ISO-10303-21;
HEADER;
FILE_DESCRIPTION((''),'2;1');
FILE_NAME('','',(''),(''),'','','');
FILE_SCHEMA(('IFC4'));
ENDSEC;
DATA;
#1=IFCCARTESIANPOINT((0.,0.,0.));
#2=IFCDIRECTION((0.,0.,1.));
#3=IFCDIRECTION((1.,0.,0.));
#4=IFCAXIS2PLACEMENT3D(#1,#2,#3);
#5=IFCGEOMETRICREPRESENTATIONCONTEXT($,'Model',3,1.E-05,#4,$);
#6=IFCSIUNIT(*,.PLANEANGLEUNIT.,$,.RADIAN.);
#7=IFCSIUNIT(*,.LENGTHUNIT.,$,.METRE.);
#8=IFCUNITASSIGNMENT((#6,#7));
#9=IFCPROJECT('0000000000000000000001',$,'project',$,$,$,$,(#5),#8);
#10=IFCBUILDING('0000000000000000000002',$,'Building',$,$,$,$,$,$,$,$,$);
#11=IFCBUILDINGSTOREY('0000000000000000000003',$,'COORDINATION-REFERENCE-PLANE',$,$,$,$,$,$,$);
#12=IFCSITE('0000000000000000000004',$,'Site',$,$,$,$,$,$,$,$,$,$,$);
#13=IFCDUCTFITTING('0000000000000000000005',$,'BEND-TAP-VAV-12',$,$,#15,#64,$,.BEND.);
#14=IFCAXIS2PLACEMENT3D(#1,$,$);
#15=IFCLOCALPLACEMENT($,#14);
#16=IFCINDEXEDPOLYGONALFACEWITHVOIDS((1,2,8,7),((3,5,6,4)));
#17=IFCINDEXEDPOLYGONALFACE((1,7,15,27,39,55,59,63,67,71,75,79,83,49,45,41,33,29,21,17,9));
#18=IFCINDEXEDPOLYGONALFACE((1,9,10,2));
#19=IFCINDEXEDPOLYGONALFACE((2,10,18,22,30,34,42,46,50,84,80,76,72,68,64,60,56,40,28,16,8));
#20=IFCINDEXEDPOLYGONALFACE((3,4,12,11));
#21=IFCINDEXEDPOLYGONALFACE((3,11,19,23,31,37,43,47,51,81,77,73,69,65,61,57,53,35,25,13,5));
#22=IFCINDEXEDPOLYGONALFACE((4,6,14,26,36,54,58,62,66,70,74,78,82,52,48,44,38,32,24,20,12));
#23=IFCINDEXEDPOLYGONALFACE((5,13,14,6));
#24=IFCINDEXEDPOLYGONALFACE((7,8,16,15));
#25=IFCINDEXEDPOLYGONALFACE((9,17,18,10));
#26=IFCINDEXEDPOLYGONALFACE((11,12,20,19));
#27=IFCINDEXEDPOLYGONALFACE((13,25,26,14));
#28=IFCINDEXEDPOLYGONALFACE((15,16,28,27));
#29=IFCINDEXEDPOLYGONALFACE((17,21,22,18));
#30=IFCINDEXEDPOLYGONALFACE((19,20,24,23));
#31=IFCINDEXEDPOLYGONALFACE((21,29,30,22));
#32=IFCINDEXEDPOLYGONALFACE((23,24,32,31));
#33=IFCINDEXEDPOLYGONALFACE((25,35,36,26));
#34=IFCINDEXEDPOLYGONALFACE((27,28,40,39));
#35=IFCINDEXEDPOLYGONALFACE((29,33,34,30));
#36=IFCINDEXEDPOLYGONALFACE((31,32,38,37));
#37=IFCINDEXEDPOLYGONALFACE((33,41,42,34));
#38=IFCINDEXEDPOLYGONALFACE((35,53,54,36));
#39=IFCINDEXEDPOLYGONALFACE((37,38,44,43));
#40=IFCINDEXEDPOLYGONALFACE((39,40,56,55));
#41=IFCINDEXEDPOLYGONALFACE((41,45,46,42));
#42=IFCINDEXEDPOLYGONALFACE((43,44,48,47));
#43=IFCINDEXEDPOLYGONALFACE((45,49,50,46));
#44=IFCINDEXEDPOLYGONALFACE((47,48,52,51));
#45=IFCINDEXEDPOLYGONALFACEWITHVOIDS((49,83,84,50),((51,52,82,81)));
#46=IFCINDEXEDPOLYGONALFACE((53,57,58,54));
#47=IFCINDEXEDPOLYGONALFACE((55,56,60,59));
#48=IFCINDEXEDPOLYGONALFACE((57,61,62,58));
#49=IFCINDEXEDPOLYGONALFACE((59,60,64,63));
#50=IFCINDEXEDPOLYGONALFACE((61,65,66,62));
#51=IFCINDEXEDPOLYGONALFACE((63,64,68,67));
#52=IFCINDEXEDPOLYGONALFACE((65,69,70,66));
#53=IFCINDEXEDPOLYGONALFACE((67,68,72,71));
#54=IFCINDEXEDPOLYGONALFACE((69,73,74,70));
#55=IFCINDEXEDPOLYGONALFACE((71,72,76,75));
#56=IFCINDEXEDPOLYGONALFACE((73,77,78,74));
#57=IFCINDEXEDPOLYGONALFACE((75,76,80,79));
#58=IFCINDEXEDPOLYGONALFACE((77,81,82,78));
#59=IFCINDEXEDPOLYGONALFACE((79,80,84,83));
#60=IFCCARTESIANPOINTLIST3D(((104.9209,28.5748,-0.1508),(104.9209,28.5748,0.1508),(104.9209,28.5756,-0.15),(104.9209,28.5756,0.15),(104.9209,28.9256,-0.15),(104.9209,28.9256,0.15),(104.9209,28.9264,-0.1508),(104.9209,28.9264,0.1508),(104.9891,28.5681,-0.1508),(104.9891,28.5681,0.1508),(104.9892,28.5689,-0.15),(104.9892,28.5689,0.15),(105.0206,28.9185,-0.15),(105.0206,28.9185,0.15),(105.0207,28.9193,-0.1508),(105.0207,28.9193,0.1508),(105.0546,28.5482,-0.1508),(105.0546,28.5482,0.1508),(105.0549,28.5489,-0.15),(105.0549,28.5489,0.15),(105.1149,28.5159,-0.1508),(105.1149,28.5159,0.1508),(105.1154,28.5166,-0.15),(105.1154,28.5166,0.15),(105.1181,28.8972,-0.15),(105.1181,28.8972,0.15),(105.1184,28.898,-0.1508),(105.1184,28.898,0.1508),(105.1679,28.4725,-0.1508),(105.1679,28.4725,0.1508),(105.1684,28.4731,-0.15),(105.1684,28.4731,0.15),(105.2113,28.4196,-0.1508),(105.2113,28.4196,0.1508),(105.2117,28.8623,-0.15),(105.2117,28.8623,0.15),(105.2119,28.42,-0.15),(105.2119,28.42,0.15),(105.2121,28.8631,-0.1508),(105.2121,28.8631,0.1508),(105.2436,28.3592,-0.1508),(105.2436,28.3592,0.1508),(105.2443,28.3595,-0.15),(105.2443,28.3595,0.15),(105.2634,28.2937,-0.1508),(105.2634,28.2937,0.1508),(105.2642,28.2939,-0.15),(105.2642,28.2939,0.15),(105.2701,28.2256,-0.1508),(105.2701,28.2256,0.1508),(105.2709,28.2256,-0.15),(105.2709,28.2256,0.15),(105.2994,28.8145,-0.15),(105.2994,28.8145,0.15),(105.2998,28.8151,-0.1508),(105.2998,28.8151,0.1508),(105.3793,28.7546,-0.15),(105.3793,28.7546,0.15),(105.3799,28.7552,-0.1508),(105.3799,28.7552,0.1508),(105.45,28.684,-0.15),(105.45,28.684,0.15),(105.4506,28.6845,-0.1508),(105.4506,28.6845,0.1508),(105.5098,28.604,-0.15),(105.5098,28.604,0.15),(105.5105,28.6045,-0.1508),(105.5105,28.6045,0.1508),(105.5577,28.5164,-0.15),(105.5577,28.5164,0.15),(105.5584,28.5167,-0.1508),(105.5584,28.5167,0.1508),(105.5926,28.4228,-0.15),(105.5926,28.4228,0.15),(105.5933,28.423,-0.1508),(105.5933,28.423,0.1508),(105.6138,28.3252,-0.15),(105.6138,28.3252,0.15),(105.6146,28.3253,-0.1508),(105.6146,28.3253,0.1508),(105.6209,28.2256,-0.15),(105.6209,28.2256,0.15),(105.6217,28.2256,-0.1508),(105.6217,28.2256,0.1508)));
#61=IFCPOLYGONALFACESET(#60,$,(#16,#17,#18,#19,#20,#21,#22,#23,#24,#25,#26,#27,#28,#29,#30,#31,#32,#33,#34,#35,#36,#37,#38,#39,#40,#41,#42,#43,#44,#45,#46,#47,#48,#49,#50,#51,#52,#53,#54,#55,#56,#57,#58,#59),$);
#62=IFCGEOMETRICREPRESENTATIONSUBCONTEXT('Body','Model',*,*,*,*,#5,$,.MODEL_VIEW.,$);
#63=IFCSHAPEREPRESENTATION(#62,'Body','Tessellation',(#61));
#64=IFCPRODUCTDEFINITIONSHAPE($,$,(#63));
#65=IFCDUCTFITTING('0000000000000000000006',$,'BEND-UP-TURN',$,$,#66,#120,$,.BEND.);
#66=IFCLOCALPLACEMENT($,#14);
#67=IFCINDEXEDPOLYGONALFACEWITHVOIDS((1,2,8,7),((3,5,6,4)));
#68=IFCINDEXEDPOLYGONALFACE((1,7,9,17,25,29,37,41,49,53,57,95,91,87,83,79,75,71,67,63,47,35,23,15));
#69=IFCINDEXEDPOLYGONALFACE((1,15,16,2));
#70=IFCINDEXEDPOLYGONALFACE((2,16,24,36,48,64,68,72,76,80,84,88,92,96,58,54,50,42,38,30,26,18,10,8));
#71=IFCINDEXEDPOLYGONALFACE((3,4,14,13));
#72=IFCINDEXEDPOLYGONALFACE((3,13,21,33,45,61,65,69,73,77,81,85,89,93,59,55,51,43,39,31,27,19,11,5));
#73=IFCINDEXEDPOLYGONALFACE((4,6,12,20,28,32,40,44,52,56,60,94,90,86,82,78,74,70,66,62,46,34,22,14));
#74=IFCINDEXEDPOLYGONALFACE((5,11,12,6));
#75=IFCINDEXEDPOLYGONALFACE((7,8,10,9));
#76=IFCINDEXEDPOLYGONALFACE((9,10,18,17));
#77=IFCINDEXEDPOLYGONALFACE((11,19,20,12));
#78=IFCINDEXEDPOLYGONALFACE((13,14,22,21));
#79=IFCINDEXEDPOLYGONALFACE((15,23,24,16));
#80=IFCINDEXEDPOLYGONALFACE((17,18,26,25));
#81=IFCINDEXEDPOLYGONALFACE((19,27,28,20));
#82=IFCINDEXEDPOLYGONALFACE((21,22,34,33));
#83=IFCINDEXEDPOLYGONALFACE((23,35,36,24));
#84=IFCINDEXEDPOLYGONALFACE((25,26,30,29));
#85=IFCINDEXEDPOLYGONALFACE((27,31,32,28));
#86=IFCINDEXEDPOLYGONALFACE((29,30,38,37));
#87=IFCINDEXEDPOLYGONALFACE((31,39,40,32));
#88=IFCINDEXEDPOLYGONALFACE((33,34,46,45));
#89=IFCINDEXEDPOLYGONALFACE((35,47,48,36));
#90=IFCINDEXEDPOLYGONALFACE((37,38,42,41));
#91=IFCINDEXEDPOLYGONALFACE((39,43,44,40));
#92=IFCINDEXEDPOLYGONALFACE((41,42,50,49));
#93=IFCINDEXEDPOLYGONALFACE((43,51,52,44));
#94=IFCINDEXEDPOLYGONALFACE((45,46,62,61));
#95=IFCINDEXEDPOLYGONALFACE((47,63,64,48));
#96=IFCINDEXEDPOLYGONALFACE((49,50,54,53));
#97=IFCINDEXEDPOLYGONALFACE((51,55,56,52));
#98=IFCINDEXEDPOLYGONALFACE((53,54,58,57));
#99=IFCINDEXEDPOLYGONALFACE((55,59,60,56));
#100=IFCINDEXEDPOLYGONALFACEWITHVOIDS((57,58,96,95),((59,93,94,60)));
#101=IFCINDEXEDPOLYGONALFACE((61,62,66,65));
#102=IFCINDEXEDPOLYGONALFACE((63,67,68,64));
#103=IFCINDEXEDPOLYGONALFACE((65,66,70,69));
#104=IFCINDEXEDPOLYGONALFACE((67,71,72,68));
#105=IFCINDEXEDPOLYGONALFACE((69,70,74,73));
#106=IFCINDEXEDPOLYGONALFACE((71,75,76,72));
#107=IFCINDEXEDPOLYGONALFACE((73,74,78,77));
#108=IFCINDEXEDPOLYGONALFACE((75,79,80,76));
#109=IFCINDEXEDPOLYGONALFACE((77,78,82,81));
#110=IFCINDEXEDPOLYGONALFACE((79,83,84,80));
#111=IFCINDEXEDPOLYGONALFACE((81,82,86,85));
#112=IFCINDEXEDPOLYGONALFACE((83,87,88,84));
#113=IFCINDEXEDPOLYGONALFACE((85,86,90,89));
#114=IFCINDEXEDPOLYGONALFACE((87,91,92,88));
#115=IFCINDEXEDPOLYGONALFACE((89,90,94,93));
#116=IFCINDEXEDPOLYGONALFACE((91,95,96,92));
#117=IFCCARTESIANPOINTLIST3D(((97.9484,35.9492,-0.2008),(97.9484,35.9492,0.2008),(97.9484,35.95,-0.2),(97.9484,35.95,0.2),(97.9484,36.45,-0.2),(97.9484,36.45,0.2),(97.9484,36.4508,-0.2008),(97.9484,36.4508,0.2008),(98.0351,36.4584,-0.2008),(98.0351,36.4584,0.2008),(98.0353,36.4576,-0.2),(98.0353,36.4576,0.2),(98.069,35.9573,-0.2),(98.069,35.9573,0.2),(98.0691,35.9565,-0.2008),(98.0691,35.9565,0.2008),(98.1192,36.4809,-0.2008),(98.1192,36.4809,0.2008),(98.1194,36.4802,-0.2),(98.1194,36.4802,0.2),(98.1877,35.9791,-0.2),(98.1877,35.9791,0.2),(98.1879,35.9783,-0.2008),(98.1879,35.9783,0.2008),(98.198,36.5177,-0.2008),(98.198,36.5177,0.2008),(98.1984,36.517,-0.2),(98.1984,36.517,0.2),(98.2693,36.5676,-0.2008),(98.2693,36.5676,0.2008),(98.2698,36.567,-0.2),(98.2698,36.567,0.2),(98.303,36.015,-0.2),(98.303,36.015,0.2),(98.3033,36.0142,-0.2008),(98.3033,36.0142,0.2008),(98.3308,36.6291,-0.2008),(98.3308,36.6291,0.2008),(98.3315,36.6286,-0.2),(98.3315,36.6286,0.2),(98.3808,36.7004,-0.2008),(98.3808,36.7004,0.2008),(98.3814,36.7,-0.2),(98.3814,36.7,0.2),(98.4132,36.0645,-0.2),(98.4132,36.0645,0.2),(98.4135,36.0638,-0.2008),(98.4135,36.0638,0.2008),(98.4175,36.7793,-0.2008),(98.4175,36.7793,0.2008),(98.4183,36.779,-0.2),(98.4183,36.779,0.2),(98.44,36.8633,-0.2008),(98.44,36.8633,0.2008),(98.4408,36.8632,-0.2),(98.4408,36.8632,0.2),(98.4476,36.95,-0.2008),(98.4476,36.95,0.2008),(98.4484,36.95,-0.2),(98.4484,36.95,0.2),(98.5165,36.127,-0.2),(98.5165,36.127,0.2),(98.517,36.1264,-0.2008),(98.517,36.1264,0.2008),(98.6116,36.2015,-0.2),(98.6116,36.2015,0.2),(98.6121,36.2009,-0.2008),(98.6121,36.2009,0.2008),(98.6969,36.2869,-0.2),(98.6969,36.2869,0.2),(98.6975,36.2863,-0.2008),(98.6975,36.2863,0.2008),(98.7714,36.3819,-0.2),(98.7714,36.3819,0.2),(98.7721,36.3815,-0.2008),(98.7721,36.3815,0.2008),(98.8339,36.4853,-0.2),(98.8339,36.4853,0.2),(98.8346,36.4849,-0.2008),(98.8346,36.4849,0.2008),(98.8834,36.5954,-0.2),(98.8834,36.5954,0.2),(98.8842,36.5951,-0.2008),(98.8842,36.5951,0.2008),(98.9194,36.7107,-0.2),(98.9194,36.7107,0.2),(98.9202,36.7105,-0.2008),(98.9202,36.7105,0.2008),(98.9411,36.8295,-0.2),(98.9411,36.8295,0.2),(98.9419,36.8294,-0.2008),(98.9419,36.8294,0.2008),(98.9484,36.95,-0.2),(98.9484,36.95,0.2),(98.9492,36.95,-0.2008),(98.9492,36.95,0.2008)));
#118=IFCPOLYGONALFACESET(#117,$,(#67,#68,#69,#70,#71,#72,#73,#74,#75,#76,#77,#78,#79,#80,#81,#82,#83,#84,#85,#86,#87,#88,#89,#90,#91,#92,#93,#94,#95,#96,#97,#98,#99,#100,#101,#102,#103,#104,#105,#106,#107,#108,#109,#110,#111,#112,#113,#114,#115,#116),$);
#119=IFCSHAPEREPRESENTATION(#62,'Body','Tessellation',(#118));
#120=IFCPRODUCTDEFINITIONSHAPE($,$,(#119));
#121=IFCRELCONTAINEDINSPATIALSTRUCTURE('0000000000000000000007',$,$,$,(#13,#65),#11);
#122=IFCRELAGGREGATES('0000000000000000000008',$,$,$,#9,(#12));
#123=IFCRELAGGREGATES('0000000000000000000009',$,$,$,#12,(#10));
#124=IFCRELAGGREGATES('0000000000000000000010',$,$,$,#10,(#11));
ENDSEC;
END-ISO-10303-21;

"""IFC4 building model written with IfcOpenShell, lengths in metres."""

from ifc_helpers import new_model, entity, si_unit, frame, origin_with_axes, place, context, subcontext, project, spatial, element, save


model = new_model("IFC4")

# Units and contexts
model_context = context("Model", 3, precision=1e-05, world=origin_with_axes())
body_context = subcontext(model_context, "Body", "Model", "MODEL_VIEW")
ifc_project = project(units=[si_unit("PLANEANGLEUNIT", "RADIAN"), si_unit("LENGTHUNIT", "METRE")], contexts=[model_context])

# Site, building, storey
site = spatial("IfcSite", under=ifc_project, Name="Site")
building = spatial("IfcBuilding", under=site, Name="Building")
storey = spatial("IfcBuildingStorey", under=building, Name="COORDINATION-REFERENCE-PLANE")

# Duct fittings
duct_fitting_1_placement = place(None, frame((104.9209, 28.2256, 0.0), z_axis=(0.0, 0.0, -1.0), x_axis=(0.0, 1.0, 0.0)))
cartesian_point_1 = entity("IfcCartesianPoint", [0.0, 0.0, 0.0])
element("IfcDuctFitting", 1, at=duct_fitting_1_placement, inside=storey, Name="BEND-TAP-VAV-12", PredefinedType="BEND", context=body_context, shape_type="SweptSolid", body=[
    entity("IfcRevolvedAreaSolid", entity("IfcRectangleHollowProfileDef", "AREA", None, entity("IfcAxis2Placement2D", entity("IfcCartesianPoint", [0.525, 0.0])), 0.3516, 0.3016, 0.0008), entity("IfcAxis2Placement3D", cartesian_point_1, entity("IfcDirection", [0.0, -1.0, 0.0]), entity("IfcDirection", [1.0, 0.0, 0.0])), entity("IfcAxis1Placement", cartesian_point_1, entity("IfcDirection", [0.0, 1.0, 0.0])), 1.570796),
])
duct_fitting_2_placement = place(None, frame((97.9484, 36.95, 0.0), z_axis=(0.0, 0.0, 1.0), x_axis=(0.0, -1.0, 0.0)))
cartesian_point_2 = entity("IfcCartesianPoint", [0.0, 0.0, 0.0])
element("IfcDuctFitting", 2, at=duct_fitting_2_placement, inside=storey, Name="BEND-UP-TURN", PredefinedType="BEND", context=body_context, shape_type="SweptSolid", body=[
    entity("IfcRevolvedAreaSolid", entity("IfcRectangleHollowProfileDef", "AREA", None, entity("IfcAxis2Placement2D", entity("IfcCartesianPoint", [0.75, 0.0])), 0.5016, 0.4016, 0.0008), entity("IfcAxis2Placement3D", cartesian_point_2, entity("IfcDirection", [0.0, -1.0, 0.0]), entity("IfcDirection", [1.0, 0.0, 0.0])), entity("IfcAxis1Placement", cartesian_point_2, entity("IfcDirection", [0.0, 1.0, 0.0])), 1.570796),
])

save(model, "model.ifc")
